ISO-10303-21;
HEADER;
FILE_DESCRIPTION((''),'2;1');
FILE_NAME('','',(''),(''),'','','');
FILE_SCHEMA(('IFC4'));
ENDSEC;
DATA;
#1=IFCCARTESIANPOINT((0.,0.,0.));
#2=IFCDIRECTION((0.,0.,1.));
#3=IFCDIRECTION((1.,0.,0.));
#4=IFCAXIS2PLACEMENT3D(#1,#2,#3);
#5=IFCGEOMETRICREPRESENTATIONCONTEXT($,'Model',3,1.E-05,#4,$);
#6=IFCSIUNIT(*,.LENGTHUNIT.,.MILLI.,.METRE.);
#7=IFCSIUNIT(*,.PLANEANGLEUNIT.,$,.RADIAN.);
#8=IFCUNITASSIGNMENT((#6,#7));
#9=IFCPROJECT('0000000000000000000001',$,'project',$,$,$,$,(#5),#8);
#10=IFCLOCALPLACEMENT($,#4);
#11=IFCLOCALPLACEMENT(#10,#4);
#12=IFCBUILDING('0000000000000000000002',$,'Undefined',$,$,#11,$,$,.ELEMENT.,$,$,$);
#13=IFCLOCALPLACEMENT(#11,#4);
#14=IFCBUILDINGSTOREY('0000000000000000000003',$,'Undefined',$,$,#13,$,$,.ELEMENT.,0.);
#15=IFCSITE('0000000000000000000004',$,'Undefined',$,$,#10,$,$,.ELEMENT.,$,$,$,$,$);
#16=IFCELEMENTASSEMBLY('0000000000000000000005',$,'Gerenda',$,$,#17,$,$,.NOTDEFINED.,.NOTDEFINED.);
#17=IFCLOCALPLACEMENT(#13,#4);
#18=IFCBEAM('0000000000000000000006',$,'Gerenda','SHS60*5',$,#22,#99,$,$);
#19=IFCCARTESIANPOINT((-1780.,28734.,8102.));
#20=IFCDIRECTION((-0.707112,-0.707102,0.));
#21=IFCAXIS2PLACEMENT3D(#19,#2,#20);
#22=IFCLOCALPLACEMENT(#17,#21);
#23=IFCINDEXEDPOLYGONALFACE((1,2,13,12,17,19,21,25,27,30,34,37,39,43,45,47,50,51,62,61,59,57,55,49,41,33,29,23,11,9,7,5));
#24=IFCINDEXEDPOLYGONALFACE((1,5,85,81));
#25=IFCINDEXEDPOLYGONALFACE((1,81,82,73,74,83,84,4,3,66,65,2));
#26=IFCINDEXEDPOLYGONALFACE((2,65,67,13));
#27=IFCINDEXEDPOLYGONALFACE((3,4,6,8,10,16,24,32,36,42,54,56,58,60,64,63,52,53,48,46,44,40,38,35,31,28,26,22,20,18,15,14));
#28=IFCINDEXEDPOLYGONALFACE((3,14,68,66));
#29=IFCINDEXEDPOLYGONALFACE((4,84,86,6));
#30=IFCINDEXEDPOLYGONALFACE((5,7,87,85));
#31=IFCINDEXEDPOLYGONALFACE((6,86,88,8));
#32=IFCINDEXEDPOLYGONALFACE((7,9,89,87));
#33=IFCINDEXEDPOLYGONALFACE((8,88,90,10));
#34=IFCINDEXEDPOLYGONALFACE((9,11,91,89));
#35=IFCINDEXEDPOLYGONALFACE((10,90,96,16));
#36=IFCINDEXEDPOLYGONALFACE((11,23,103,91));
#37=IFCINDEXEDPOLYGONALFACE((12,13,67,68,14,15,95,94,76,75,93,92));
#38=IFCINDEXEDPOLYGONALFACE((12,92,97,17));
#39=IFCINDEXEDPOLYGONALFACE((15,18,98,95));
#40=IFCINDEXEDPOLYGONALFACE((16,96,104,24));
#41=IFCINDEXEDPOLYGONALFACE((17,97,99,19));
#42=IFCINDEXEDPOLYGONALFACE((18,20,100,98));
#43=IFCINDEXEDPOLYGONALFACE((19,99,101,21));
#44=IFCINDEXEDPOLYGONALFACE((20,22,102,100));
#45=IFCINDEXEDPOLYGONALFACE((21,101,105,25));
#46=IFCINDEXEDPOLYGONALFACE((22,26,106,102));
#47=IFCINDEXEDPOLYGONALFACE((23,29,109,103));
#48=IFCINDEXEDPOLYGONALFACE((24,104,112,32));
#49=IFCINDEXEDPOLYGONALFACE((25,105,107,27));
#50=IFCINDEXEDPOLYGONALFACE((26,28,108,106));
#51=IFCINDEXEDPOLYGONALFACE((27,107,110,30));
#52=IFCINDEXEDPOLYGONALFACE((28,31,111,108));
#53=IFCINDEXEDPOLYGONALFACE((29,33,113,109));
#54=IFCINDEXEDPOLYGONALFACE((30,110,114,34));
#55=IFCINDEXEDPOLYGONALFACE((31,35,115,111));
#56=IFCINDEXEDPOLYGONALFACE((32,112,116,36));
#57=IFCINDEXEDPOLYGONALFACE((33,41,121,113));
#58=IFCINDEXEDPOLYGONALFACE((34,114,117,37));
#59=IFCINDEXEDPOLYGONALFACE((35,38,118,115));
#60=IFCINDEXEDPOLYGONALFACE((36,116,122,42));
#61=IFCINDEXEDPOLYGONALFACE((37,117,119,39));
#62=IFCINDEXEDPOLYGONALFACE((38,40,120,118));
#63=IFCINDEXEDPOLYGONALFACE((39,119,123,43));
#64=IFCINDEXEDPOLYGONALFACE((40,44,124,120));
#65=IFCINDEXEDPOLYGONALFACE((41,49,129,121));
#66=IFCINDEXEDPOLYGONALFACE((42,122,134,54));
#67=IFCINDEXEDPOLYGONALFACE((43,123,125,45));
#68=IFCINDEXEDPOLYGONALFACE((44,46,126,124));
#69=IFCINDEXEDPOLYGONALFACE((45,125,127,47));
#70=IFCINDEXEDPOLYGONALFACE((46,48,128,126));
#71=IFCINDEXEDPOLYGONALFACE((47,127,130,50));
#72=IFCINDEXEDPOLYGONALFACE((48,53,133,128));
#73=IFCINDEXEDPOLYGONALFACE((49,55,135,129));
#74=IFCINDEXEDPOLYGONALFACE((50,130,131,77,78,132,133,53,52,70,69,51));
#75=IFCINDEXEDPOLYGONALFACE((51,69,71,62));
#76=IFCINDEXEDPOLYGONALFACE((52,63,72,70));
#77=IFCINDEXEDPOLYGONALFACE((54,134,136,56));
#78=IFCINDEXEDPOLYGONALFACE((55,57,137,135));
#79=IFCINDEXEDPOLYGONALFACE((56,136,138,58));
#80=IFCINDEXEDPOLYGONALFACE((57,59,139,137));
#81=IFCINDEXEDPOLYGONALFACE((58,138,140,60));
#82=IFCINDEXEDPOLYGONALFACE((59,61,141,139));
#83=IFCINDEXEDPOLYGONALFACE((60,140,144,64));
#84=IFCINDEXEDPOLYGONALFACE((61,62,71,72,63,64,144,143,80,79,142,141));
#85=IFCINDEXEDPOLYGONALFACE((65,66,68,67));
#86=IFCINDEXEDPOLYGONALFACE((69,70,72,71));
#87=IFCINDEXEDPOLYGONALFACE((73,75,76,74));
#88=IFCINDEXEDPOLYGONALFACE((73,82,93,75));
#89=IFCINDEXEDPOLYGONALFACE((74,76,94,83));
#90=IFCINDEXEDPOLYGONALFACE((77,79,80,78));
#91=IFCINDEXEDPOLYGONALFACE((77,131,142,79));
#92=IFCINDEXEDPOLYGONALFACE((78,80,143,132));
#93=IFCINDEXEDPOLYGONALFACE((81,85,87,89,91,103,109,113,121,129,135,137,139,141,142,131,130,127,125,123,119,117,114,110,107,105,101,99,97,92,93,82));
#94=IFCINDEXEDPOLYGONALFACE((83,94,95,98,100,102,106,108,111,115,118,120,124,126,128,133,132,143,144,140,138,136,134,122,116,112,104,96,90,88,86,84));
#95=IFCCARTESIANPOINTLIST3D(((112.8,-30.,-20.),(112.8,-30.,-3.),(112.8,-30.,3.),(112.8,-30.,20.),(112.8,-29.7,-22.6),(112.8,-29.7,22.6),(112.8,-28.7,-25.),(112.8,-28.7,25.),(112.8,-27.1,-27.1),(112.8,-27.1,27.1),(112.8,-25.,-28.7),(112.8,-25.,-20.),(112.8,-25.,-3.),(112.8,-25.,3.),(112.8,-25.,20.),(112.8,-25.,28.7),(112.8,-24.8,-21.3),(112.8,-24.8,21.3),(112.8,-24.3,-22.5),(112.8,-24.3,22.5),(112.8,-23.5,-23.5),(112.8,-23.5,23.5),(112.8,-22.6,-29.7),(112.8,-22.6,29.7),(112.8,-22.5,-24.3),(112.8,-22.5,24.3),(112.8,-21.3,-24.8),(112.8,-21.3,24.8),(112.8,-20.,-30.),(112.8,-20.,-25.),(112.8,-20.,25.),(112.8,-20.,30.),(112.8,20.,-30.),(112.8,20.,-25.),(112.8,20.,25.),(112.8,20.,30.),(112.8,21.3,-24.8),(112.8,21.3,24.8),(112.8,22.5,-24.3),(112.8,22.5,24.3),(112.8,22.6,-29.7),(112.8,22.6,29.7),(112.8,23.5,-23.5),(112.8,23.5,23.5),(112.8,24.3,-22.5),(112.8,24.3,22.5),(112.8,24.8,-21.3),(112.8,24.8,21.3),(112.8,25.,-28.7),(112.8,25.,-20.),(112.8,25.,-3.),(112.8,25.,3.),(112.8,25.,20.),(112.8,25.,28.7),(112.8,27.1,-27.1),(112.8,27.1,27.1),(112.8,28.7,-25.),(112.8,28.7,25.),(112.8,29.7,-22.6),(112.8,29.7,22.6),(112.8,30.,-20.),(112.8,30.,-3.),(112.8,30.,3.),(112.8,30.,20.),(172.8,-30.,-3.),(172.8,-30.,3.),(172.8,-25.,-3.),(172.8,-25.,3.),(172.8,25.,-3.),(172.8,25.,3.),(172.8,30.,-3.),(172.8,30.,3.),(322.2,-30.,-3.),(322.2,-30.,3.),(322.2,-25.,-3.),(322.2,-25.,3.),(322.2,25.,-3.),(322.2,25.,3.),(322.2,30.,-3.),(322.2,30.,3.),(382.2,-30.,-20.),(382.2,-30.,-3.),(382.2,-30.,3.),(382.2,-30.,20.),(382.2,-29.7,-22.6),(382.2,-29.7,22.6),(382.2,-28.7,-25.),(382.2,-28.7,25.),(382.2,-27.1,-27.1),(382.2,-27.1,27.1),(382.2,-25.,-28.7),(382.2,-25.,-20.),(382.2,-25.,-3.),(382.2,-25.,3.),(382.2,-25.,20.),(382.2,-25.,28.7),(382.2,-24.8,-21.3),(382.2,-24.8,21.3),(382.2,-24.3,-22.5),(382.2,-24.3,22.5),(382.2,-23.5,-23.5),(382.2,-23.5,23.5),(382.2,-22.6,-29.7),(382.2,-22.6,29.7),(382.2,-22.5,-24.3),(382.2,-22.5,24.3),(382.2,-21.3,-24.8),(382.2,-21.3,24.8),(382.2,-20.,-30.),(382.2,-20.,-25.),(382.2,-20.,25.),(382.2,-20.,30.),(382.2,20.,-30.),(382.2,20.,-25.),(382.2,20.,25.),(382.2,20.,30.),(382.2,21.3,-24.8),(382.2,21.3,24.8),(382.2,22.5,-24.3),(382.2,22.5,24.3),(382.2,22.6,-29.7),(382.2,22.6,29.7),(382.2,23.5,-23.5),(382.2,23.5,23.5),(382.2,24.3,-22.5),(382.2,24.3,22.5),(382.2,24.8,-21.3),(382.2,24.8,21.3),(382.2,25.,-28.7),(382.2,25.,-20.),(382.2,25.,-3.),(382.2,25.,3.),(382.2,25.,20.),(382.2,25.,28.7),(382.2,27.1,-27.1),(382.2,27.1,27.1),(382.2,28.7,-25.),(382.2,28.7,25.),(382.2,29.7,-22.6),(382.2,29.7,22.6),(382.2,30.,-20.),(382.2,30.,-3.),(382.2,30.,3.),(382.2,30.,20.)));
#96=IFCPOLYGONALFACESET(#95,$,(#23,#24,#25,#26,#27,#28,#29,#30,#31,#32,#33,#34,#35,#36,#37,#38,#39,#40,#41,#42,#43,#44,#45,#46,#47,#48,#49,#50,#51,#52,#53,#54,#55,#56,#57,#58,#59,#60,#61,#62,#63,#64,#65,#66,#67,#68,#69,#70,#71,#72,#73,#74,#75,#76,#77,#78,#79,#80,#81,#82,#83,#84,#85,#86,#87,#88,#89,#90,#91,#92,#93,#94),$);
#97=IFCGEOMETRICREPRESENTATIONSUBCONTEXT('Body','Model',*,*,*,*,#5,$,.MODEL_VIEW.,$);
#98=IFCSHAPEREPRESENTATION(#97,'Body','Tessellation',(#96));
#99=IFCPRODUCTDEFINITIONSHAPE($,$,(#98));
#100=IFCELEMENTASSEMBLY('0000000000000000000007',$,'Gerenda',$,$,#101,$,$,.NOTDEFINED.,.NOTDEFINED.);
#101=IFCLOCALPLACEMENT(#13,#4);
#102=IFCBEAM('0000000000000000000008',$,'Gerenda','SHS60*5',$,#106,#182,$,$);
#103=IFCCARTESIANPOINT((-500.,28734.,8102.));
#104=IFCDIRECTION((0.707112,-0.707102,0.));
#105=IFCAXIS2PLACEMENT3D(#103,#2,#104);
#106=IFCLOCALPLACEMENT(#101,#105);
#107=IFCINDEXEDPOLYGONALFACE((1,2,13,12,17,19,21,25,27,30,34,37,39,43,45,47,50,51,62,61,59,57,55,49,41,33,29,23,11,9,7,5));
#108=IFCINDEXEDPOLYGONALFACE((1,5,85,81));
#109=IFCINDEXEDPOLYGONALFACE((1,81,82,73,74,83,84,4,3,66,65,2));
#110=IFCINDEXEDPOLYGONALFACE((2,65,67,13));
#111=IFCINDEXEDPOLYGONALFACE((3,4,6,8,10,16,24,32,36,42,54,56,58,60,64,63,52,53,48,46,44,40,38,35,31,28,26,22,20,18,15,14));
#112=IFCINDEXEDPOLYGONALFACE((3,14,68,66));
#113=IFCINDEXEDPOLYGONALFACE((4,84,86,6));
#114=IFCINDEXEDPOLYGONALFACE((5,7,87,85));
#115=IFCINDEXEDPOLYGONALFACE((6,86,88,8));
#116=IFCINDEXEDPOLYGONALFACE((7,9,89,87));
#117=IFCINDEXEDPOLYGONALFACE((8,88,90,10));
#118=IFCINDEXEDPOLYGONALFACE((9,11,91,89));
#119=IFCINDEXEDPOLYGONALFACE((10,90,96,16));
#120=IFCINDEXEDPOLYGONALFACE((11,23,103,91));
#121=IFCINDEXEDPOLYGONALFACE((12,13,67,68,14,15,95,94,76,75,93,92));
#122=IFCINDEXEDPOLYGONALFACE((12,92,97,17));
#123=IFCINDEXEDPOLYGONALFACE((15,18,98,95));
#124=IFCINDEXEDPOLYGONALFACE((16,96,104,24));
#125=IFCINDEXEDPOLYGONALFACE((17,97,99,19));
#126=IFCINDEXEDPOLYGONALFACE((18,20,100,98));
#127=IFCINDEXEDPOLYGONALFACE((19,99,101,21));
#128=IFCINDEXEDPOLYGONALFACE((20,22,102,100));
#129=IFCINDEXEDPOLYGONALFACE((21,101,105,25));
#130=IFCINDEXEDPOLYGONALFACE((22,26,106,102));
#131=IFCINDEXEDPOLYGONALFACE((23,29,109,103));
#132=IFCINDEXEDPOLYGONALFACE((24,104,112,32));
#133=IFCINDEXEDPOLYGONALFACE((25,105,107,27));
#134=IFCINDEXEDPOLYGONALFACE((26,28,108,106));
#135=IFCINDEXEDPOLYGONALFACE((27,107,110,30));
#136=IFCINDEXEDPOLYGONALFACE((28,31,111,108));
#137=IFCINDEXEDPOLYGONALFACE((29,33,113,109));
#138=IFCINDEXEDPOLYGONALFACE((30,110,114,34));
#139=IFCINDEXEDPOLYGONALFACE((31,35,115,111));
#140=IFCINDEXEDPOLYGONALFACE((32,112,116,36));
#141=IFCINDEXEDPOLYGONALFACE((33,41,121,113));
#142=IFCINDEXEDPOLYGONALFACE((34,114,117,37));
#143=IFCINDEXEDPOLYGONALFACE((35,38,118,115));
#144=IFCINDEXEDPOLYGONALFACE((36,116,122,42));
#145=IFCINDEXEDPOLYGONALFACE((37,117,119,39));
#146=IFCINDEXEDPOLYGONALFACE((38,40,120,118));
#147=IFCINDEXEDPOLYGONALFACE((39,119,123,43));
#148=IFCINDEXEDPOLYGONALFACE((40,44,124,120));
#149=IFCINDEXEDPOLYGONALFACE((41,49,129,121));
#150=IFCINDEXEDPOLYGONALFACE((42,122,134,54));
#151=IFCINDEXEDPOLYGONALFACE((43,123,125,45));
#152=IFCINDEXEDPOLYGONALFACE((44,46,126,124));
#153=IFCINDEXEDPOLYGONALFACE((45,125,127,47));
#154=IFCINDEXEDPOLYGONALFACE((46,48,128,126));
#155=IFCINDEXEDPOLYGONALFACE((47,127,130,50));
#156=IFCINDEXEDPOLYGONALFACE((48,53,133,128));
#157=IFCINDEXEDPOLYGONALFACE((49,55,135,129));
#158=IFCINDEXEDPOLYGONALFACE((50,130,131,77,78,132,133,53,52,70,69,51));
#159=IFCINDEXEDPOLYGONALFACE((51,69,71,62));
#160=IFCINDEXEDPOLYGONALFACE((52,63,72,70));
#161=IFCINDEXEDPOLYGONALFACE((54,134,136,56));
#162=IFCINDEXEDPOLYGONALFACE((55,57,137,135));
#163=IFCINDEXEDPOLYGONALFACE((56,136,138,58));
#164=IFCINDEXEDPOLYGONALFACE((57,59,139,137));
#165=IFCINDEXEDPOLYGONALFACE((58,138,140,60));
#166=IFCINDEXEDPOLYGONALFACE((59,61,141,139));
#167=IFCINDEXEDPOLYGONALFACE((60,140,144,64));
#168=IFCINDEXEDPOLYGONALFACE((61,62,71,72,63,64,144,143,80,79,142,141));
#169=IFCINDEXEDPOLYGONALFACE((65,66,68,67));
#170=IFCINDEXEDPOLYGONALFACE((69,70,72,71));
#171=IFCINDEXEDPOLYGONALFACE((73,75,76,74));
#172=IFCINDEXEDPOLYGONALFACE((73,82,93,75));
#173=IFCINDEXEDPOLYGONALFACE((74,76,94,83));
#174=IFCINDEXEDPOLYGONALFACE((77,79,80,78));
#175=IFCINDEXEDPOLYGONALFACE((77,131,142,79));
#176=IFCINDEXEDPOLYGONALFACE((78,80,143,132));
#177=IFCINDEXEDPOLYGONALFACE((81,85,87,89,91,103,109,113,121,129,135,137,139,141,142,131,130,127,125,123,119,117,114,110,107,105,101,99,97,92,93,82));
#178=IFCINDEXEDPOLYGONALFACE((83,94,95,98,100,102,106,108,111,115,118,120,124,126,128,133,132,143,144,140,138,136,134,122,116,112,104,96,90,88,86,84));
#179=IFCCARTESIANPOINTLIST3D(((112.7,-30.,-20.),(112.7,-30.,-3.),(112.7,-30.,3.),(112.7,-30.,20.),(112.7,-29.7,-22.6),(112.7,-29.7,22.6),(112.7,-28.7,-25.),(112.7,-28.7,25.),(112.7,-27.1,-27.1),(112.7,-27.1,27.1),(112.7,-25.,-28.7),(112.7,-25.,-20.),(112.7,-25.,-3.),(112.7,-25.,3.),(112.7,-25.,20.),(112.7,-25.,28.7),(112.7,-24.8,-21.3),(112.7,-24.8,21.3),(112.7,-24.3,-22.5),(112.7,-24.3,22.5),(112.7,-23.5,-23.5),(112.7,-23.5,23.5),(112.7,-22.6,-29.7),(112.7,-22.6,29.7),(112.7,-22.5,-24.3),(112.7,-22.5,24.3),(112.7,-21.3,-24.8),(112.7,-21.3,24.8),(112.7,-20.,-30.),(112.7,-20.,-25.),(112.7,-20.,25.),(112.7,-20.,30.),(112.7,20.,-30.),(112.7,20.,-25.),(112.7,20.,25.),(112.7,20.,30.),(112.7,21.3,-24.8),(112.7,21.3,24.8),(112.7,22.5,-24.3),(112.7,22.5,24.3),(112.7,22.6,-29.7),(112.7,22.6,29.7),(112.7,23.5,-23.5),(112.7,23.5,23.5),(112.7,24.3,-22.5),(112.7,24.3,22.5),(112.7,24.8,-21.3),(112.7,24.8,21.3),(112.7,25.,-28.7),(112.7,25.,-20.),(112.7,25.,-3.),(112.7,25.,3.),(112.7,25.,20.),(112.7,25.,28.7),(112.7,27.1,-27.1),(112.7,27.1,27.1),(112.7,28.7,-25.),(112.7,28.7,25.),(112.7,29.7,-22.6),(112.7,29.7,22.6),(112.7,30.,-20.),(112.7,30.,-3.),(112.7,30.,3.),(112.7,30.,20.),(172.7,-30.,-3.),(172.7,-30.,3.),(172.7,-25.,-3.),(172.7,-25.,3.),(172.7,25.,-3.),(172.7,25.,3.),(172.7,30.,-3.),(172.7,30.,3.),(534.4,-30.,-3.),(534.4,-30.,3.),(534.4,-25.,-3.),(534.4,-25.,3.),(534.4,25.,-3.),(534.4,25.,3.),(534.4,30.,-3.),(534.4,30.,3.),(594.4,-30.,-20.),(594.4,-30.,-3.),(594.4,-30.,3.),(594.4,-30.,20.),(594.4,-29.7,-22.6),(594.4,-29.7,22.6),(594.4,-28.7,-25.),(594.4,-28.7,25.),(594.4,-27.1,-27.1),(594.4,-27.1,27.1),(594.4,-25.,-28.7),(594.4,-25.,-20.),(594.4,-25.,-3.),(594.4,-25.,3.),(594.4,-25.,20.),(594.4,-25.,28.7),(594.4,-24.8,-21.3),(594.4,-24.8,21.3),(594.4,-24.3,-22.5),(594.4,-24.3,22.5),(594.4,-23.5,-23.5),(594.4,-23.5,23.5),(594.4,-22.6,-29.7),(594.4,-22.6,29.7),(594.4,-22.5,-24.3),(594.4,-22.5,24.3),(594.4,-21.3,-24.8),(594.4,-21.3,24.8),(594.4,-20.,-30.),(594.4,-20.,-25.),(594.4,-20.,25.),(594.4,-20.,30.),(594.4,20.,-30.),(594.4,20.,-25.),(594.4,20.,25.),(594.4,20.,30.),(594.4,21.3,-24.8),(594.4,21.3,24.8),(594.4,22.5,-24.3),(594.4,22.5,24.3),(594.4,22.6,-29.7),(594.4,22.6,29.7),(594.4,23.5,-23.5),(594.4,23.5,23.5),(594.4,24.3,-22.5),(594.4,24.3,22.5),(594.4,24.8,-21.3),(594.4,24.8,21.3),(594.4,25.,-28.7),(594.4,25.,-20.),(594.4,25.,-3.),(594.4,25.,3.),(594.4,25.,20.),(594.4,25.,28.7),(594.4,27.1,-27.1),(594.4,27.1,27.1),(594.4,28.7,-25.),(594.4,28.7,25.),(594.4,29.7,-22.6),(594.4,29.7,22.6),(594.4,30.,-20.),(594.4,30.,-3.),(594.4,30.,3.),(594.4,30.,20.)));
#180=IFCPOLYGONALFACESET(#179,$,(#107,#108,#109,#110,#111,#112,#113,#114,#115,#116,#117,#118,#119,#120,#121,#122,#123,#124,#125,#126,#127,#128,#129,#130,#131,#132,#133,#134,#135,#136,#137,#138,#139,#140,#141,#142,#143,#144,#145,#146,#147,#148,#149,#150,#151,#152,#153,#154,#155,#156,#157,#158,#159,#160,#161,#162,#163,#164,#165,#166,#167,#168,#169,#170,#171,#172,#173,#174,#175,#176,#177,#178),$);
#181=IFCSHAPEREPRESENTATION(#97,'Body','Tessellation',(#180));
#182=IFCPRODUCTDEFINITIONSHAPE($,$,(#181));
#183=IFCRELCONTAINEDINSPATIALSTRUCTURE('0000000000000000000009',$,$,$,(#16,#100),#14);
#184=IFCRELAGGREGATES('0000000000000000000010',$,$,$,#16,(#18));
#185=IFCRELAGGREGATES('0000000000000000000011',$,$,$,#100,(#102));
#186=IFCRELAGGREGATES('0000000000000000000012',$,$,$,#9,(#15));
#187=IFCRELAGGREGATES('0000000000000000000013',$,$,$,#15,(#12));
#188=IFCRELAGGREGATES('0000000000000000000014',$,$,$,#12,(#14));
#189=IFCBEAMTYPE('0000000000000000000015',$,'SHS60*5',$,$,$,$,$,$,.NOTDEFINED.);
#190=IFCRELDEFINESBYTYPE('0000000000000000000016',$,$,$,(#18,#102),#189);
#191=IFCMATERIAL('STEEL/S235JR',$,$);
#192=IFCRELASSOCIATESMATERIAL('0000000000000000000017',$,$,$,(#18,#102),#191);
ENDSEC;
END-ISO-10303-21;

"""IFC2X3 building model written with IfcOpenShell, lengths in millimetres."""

from ifc_helpers import new_model, si_unit, frame, origin_with_axes, origin_2d_with_axis, place, context, subcontext, project, spatial, rectangle, hollow_rectangle, extrude, boolean, halfspace, material, type_object, element, aggregate, save


model = new_model("IFC2X3")

# Units and contexts
model_context = context("Model", 3, precision=1e-05, world=origin_with_axes())
body_context = subcontext(model_context, "Body", "Model", "MODEL_VIEW")
ifc_project = project(units=[si_unit("LENGTHUNIT", "METRE", prefix="MILLI"), si_unit("PLANEANGLEUNIT", "RADIAN")], contexts=[model_context])

# Site, building, storey
site_placement = place(None, origin_with_axes())
site = spatial("IfcSite", under=ifc_project, at=site_placement, Name="Undefined", CompositionType="ELEMENT")
building_placement = place(site_placement, origin_with_axes())
building = spatial("IfcBuilding", under=site, at=building_placement, Name="Undefined", CompositionType="ELEMENT")
storey_placement = place(building_placement, origin_with_axes())
storey = spatial("IfcBuildingStorey", under=building, at=storey_placement, Name="Undefined", CompositionType="ELEMENT", Elevation=0.0)

# Element assemblies, beams
assembly_1_placement = place(storey_placement, origin_with_axes())
assembly_1 = element("IfcElementAssembly", 1, at=assembly_1_placement, inside=storey, Name="Gerenda", AssemblyPlace="NOTDEFINED", PredefinedType="NOTDEFINED")
ifc_material_1 = material(Name="STEEL/S235JR")
beam_type_1 = type_object("IfcBeamType", Name="SHS60*5", PredefinedType="NOTDEFINED")
beam_1_placement = place(assembly_1_placement, frame((-1780.0, 28734.0, 8102.0), z_axis=(0.0, 0.0, 1.0), x_axis=(-0.707112, -0.707102, 0.0)))
beam_1 = element("IfcBeam", 2, at=beam_1_placement, type_object=beam_type_1, material=ifc_material_1, Name="Gerenda", Description="SHS60*5", context=body_context, shape_type="CSG", body=[
    boolean("DIFFERENCE", boolean("DIFFERENCE", boolean("DIFFERENCE", boolean("DIFFERENCE", extrude(hollow_rectangle(XDim=60.0, YDim=60.0, WallThickness=5.0, InnerFilletRadius=5.0, OuterFilletRadius=10.0, at=origin_2d_with_axis()), frame((442.8, 0.0, 0.0), z_axis=(-1.0, 0.0, 0.0), x_axis=(0.0, -1.0, 0.0)), (0.0, 0.0, 1.0), 442.8), extrude(rectangle(XDim=6.0, YDim=64.0, at=origin_2d_with_axis()), frame((322.2, 0.0, 0.0), z_axis=(1.0, 0.0, 0.0), x_axis=(0.0, 0.0, -1.0)), (0.0, 0.0, 1.0), 62.0)), extrude(rectangle(XDim=6.0, YDim=64.0, at=origin_2d_with_axis()), frame((172.8, 0.0, 0.0), z_axis=(-1.0, 0.0, 0.0), x_axis=(0.0, 0.0, -1.0)), (0.0, 0.0, 1.0), 62.0)), halfspace(frame((382.2, 0.0, -9.0), z_axis=(-1.0, 0.0, 0.0), x_axis=(0.0, 1.0, 0.0)), True)), halfspace(frame((112.8, 0.0, -9.0), z_axis=(1.0, 0.0, 0.0), x_axis=(0.0, -1.0, 0.0)), True)),
])
assembly_2_placement = place(storey_placement, origin_with_axes())
assembly_2 = element("IfcElementAssembly", 3, at=assembly_2_placement, inside=storey, Name="Gerenda", AssemblyPlace="NOTDEFINED", PredefinedType="NOTDEFINED")
beam_2_placement = place(assembly_2_placement, frame((-500.0, 28734.0, 8102.0), z_axis=(0.0, 0.0, 1.0), x_axis=(0.707112, -0.707102, 0.0)))
beam_2 = element("IfcBeam", 4, at=beam_2_placement, type_object=beam_type_1, material=ifc_material_1, Name="Gerenda", Description="SHS60*5", context=body_context, shape_type="CSG", body=[
    boolean("DIFFERENCE", boolean("DIFFERENCE", boolean("DIFFERENCE", boolean("DIFFERENCE", extrude(hollow_rectangle(XDim=60.0, YDim=60.0, WallThickness=5.0, InnerFilletRadius=5.0, OuterFilletRadius=10.0, at=origin_2d_with_axis()), frame((707.1, 0.0, 0.0), z_axis=(-1.0, 0.0, 0.0), x_axis=(0.0, -1.0, 0.0)), (0.0, 0.0, 1.0), 707.1), extrude(rectangle(XDim=6.0, YDim=64.0, at=origin_2d_with_axis()), frame((172.7, 0.0, 0.0), z_axis=(-1.0, 0.0, 0.0), x_axis=(0.0, 0.0, -1.0)), (0.0, 0.0, 1.0), 62.0)), extrude(rectangle(XDim=6.0, YDim=64.0, at=origin_2d_with_axis()), frame((534.4, 0.0, 0.0), z_axis=(1.0, 0.0, 0.0), x_axis=(0.0, 0.0, -1.0)), (0.0, 0.0, 1.0), 62.0)), halfspace(frame((594.4, 0.0, -9.0), z_axis=(-1.0, 0.0, 0.0), x_axis=(0.0, 1.0, 0.0)), True)), halfspace(frame((112.7, 0.0, -9.0), z_axis=(1.0, 0.0, 0.0), x_axis=(0.0, -1.0, 0.0)), True)),
])

aggregate(assembly_1, [beam_1])
aggregate(assembly_2, [beam_2])

save(model, "model.ifc")
